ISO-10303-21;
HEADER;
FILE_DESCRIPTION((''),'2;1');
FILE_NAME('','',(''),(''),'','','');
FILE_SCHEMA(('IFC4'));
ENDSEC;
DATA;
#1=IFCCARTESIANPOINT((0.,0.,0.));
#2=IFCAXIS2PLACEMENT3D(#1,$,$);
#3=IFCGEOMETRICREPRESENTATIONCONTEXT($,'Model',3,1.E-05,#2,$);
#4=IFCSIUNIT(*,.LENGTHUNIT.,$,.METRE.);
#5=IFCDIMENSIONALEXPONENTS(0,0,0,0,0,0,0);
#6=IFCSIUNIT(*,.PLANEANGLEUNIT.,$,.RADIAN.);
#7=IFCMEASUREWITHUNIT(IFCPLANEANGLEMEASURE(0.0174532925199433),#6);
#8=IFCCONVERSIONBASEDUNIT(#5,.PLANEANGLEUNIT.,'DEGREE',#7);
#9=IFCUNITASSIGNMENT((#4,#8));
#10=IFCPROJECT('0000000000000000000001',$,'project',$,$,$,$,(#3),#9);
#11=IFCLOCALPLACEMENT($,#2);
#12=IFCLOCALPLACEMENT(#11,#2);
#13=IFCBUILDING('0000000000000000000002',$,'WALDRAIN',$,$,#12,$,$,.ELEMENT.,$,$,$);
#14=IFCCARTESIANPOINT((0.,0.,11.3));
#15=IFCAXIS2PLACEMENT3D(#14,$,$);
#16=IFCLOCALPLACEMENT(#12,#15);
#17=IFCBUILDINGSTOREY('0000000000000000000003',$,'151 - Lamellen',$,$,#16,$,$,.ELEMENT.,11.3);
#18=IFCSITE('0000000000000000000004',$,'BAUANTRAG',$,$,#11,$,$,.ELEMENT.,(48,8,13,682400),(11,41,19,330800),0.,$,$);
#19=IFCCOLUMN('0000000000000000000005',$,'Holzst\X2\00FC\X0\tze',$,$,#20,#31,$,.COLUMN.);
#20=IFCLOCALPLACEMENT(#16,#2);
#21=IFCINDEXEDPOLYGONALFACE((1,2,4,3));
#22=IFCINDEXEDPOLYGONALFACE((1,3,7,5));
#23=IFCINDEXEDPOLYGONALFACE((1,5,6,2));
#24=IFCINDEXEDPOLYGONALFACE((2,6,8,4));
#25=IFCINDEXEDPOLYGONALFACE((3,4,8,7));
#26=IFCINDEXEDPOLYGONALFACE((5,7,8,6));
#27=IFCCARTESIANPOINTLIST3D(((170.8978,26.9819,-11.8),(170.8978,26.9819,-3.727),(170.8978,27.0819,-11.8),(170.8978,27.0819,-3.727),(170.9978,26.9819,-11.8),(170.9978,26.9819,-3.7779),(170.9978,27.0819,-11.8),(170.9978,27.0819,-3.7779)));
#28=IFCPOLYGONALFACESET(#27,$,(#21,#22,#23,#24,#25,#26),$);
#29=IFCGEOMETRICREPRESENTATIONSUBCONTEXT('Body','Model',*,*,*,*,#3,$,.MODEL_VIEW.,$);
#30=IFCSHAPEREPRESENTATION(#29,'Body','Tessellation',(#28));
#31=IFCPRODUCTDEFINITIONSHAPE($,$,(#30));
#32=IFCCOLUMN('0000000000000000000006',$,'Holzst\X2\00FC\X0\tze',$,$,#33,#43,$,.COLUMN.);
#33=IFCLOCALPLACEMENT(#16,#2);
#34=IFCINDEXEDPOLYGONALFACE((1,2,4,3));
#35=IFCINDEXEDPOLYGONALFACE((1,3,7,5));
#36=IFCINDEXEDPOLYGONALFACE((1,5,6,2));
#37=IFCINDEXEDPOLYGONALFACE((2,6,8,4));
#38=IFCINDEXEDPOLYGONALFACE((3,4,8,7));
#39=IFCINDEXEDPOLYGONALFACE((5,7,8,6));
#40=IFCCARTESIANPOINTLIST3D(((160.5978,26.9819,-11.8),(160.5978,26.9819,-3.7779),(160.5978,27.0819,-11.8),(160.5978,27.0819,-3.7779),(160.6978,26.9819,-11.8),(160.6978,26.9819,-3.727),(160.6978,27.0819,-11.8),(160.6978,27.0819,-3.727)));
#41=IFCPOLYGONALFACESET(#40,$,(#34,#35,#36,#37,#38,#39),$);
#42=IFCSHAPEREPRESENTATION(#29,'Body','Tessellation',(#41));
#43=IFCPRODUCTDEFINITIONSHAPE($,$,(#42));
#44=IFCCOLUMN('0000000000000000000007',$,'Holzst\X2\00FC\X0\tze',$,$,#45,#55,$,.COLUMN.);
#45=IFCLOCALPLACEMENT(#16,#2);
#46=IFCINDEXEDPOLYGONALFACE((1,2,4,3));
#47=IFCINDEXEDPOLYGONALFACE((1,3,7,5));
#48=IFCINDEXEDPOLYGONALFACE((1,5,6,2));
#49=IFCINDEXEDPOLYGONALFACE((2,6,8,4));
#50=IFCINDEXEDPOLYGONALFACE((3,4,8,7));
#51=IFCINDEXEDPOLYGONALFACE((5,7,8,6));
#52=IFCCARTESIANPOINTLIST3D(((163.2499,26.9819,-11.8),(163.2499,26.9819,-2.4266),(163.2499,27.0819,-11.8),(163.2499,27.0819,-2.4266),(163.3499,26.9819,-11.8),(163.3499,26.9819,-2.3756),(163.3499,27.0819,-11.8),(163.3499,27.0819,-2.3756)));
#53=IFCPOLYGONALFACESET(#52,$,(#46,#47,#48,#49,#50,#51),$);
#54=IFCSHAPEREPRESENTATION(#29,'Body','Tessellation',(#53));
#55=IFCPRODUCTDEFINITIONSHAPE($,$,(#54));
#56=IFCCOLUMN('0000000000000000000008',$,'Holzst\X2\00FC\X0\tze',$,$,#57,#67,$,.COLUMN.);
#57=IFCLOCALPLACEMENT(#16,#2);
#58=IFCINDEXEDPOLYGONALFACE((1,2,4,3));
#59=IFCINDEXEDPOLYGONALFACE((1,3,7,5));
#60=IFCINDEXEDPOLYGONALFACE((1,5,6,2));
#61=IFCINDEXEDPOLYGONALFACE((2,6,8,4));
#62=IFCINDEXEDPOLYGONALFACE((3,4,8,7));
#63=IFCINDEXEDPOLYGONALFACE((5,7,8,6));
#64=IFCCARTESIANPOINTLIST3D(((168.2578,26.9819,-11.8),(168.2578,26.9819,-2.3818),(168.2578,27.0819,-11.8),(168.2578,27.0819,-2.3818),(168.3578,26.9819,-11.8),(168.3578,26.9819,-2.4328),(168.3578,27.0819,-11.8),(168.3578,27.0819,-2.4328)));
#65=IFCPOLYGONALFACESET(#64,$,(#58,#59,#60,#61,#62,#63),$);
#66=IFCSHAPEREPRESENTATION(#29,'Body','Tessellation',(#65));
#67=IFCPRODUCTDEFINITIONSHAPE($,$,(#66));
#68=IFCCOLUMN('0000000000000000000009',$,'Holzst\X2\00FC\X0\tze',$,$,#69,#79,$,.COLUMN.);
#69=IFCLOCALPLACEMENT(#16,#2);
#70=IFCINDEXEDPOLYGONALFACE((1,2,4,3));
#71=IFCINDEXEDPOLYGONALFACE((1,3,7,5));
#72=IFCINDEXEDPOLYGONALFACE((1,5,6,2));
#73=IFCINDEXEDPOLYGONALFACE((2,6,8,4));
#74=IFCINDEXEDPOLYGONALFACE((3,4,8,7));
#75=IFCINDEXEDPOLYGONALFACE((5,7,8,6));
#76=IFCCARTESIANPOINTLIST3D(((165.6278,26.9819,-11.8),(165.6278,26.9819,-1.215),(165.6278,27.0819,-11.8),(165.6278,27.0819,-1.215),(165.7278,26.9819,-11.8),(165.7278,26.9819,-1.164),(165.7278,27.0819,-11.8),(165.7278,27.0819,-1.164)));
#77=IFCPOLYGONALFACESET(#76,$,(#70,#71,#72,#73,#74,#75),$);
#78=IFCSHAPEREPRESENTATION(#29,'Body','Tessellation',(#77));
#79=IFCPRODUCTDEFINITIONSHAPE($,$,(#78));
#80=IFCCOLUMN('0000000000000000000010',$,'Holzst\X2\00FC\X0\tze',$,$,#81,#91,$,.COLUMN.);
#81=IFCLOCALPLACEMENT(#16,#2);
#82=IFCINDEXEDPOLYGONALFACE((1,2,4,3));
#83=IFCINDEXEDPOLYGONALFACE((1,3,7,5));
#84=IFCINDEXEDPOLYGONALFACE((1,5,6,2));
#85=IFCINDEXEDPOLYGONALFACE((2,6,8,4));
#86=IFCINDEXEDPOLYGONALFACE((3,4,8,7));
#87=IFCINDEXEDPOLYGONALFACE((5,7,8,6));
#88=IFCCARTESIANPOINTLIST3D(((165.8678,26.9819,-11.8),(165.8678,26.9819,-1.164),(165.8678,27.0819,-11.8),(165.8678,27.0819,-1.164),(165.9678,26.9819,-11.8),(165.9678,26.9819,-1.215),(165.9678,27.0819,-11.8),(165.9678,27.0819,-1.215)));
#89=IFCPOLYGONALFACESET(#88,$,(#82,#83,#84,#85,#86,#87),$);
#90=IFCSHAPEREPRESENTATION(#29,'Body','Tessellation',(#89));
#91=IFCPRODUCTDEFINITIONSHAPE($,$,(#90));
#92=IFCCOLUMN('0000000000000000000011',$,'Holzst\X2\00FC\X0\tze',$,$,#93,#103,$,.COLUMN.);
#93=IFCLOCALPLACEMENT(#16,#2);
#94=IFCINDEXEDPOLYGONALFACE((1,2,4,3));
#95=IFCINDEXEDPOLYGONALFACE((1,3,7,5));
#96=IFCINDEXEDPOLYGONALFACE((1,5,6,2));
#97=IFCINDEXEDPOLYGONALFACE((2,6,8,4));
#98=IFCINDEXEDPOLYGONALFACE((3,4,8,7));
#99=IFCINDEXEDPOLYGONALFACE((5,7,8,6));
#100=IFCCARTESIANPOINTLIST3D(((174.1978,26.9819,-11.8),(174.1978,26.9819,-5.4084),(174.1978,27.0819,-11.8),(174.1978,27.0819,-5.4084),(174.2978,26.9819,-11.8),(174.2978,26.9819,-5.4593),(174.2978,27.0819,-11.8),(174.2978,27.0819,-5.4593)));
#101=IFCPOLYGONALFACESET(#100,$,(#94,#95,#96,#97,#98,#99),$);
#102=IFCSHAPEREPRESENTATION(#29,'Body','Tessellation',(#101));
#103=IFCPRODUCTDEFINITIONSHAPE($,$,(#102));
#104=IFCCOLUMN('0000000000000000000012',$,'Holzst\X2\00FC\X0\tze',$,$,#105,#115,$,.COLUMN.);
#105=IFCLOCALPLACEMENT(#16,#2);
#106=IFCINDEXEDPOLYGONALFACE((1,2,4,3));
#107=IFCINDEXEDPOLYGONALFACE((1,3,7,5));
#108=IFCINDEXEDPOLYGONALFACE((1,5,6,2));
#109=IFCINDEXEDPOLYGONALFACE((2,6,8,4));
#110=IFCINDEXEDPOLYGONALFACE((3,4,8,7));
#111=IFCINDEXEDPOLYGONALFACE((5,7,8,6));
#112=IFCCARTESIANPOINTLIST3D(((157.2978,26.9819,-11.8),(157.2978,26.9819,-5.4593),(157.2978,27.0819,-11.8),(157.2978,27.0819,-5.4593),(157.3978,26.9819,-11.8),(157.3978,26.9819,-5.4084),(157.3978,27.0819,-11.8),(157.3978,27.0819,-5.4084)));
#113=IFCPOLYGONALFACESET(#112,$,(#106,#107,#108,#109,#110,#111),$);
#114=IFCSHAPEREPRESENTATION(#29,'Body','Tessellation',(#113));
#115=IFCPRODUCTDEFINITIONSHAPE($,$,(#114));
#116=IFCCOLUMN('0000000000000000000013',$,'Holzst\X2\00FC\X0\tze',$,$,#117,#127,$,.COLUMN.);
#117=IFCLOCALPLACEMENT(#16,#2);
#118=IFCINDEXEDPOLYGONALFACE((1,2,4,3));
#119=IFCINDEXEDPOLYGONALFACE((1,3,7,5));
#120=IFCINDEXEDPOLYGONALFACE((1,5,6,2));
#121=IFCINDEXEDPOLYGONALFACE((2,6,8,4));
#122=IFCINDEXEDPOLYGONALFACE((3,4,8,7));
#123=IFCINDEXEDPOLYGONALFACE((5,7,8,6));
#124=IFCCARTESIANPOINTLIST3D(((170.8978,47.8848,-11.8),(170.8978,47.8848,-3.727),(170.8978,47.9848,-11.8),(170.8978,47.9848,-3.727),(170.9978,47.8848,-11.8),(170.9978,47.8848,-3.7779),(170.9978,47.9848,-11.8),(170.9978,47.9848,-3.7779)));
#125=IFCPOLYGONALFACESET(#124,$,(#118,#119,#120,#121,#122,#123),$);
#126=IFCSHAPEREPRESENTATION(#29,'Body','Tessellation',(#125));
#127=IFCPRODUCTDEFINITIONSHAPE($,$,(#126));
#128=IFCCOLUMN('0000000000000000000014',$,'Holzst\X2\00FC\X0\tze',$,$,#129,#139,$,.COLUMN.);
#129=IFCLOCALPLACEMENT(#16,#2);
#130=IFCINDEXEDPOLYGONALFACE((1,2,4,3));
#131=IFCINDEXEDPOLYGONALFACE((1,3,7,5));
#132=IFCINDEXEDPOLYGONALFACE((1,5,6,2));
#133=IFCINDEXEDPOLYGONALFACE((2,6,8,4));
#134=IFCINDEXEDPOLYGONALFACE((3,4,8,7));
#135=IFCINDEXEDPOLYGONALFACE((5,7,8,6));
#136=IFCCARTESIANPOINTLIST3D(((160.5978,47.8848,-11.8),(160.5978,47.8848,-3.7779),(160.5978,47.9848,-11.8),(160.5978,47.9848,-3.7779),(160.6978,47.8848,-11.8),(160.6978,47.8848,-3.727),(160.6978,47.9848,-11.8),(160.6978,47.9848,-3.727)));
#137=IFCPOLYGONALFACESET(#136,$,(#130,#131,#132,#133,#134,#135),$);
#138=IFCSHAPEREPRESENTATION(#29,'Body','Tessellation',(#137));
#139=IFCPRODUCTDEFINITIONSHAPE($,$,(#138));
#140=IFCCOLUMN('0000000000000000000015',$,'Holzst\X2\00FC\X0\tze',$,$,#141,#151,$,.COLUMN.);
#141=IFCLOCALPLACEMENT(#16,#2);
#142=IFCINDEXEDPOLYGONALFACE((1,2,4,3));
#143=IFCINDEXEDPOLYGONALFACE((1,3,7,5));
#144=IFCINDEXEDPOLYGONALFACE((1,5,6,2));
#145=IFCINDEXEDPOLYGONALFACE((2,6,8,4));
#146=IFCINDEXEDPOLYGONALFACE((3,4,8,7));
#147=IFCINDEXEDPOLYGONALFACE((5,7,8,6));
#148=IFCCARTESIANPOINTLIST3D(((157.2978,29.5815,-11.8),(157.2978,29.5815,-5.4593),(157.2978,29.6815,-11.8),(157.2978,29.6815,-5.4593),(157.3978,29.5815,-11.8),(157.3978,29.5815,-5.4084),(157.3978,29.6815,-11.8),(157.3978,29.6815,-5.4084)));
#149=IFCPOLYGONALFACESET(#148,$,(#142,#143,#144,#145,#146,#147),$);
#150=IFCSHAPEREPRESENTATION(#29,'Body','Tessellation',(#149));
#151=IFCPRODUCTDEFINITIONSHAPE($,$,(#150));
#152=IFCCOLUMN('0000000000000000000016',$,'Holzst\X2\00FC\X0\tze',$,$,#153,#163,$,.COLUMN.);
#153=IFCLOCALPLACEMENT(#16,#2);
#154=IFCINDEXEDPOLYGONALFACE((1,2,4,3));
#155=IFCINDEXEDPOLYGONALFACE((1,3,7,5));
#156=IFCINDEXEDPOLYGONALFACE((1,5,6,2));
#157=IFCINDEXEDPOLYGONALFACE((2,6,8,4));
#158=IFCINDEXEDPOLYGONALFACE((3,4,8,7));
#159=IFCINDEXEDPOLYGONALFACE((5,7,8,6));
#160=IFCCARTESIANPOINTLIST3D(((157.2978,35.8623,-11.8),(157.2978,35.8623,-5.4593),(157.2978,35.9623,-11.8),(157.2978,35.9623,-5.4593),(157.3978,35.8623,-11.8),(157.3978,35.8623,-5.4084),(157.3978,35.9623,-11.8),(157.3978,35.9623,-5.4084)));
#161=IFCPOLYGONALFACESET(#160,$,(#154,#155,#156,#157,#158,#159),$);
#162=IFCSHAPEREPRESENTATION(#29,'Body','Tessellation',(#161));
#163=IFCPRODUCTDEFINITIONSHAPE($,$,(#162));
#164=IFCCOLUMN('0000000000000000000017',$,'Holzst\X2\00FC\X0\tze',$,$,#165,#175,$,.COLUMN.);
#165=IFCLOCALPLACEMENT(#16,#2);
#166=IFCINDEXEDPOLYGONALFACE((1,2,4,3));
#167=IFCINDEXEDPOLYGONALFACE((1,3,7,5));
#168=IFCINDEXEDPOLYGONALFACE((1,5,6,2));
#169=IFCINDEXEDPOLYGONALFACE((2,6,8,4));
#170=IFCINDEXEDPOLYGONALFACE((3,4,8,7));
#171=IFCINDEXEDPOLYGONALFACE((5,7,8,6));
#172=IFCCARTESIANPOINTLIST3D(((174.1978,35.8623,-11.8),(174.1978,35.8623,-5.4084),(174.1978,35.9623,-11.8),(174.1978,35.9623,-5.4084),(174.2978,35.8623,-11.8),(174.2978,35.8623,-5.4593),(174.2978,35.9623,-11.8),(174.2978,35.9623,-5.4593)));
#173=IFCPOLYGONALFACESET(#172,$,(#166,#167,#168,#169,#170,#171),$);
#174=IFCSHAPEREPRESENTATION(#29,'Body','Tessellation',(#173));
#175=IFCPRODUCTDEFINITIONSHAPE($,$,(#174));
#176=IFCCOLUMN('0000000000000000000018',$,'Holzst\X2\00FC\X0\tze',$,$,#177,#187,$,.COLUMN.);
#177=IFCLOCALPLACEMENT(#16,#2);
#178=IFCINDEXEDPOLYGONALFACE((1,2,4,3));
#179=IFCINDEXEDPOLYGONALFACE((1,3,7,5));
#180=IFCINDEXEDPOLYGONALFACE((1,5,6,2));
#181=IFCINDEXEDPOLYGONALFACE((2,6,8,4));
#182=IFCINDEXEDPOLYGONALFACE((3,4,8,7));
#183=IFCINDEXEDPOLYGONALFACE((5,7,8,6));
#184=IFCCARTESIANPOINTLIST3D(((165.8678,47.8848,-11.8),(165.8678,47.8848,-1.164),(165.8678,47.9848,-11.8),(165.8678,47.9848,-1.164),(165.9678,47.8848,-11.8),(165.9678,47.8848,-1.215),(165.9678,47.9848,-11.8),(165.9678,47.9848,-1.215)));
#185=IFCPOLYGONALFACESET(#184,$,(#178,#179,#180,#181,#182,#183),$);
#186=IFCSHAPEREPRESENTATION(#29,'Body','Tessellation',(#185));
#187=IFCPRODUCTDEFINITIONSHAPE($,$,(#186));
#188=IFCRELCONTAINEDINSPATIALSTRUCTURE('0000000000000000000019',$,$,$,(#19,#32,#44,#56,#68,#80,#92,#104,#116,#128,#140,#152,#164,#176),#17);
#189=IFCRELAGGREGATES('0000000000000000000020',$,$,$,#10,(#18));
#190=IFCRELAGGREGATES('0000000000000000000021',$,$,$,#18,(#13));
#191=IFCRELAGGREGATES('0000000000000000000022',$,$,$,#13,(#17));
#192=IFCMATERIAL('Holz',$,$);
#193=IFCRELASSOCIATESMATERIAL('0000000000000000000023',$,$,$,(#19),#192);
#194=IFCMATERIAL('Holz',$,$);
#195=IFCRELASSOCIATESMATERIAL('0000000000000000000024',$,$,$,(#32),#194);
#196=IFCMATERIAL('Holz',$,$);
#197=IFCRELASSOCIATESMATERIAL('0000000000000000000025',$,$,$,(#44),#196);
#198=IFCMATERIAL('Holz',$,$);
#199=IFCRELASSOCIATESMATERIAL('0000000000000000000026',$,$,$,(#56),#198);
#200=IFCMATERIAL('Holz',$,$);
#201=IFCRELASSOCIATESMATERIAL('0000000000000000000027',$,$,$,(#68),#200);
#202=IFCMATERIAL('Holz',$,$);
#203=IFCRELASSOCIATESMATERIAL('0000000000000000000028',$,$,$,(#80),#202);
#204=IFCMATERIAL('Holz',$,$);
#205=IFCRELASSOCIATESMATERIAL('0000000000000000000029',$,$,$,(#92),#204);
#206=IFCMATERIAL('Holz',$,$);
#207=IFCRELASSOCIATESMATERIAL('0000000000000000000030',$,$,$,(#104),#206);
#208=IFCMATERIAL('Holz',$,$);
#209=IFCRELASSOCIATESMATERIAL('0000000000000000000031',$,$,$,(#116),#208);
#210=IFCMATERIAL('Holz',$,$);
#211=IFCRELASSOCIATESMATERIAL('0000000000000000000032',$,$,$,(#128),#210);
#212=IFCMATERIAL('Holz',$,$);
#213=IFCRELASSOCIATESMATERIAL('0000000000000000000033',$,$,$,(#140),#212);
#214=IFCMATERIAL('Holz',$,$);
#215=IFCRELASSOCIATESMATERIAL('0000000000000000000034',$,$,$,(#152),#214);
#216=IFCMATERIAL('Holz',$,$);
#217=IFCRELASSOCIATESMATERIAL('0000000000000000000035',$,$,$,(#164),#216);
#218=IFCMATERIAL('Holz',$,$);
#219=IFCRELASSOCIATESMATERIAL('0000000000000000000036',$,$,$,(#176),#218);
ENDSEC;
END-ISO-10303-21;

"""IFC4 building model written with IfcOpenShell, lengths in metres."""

from ifc_helpers import new_model, entity, si_unit, converted_unit, frame, frame_2d, origin, origin_with_axes, place, context, subcontext, project, spatial, rectangle, extrude, clip, halfspace, material, element, save


model = new_model("IFC4")

# Units and contexts
model_context = context("Model", 3, precision=1e-05, world=origin())
body_context = subcontext(model_context, "Body", "Model", "MODEL_VIEW")
ifc_project = project(units=[si_unit("LENGTHUNIT", "METRE"), converted_unit("PLANEANGLEUNIT", "DEGREE", entity("IfcPlaneAngleMeasure", 0.0174532925199433), si_unit("PLANEANGLEUNIT", "RADIAN"), dimensions=[0, 0, 0, 0, 0, 0, 0])], contexts=[model_context])

# Site, building, storey
site_placement = place(None, origin())
site = spatial("IfcSite", under=ifc_project, at=site_placement, Name="BAUANTRAG", CompositionType="ELEMENT", RefLatitude=(48, 8, 13, 682400), RefLongitude=(11, 41, 19, 330800), RefElevation=0.0)
building_placement = place(site_placement, origin())
building = spatial("IfcBuilding", under=site, at=building_placement, Name="WALDRAIN", CompositionType="ELEMENT")
storey_placement = place(building_placement, frame((0.0, 0.0, 11.3)))
storey = spatial("IfcBuildingStorey", under=building, at=storey_placement, Name="151 - Lamellen", CompositionType="ELEMENT", Elevation=11.3)

# Columns
ifc_material_1 = material(Name="Holz")
column_1_placement = place(storey_placement, frame((170.9978, 26.9819, -11.8)))
element("IfcColumn", 1, at=column_1_placement, inside=storey, material=ifc_material_1, Name="Holzstütze", PredefinedType="COLUMN", context=body_context, shape_type="Clipping", body=[
    clip(extrude(rectangle(XDim=0.1, YDim=0.1, at=frame_2d((-0.05, 0.05), x_axis=(0.0, 1.0))), origin_with_axes(), (0.0, 0.0, 1.0), 8.073), halfspace(frame((-0.05, 0.05, 8.0476), z_axis=(-0.45399, 0.0, -0.891007), x_axis=(0.0, -1.0, 0.0)), True)),
])
ifc_material_2 = material(Name="Holz")
column_2_placement = place(storey_placement, frame((160.6978, 26.9819, -11.8)))
element("IfcColumn", 2, at=column_2_placement, inside=storey, material=ifc_material_2, Name="Holzstütze", PredefinedType="COLUMN", context=body_context, shape_type="Clipping", body=[
    clip(extrude(rectangle(XDim=0.1, YDim=0.1, at=frame_2d((-0.05, 0.05), x_axis=(0.0, 1.0))), origin_with_axes(), (0.0, 0.0, 1.0), 8.073), halfspace(frame((-0.05, 0.05, 8.0476), z_axis=(0.45399, 0.0, -0.891007), x_axis=(0.0, -1.0, 0.0)), True)),
])
ifc_material_3 = material(Name="Holz")
column_3_placement = place(storey_placement, frame((163.3499, 26.9819, -11.8)))
element("IfcColumn", 3, at=column_3_placement, inside=storey, material=ifc_material_3, Name="Holzstütze", PredefinedType="COLUMN", context=body_context, shape_type="Clipping", body=[
    clip(extrude(rectangle(XDim=0.1, YDim=0.1, at=frame_2d((-0.05, 0.05), x_axis=(0.0, 1.0))), origin_with_axes(), (0.0, 0.0, 1.0), 9.4244), halfspace(frame((-0.05, 0.05, 9.3989), z_axis=(0.45399, 0.0, -0.891007), x_axis=(0.0, -1.0, 0.0)), True)),
])
ifc_material_4 = material(Name="Holz")
column_4_placement = place(storey_placement, frame((168.3578, 26.9819, -11.8)))
element("IfcColumn", 4, at=column_4_placement, inside=storey, material=ifc_material_4, Name="Holzstütze", PredefinedType="COLUMN", context=body_context, shape_type="Clipping", body=[
    clip(extrude(rectangle(XDim=0.1, YDim=0.1, at=frame_2d((-0.05, 0.05), x_axis=(0.0, 1.0))), origin_with_axes(), (0.0, 0.0, 1.0), 9.4182), halfspace(frame((-0.05, 0.05, 9.3927), z_axis=(-0.45399, 0.0, -0.891007), x_axis=(0.0, -1.0, 0.0)), True)),
])
ifc_material_5 = material(Name="Holz")
column_5_placement = place(storey_placement, frame((165.7278, 26.9819, -11.8)))
element("IfcColumn", 5, at=column_5_placement, inside=storey, material=ifc_material_5, Name="Holzstütze", PredefinedType="COLUMN", context=body_context, shape_type="Clipping", body=[
    clip(extrude(rectangle(XDim=0.1, YDim=0.1, at=frame_2d((-0.05, 0.05), x_axis=(0.0, 1.0))), origin_with_axes(), (0.0, 0.0, 1.0), 10.636), halfspace(frame((-0.05, 0.05, 10.6105), z_axis=(0.45399, 0.0, -0.891007), x_axis=(0.0, -1.0, 0.0)), True)),
])
ifc_material_6 = material(Name="Holz")
column_6_placement = place(storey_placement, frame((165.9678, 26.9819, -11.8)))
element("IfcColumn", 6, at=column_6_placement, inside=storey, material=ifc_material_6, Name="Holzstütze", PredefinedType="COLUMN", context=body_context, shape_type="Clipping", body=[
    clip(extrude(rectangle(XDim=0.1, YDim=0.1, at=frame_2d((-0.05, 0.05), x_axis=(0.0, 1.0))), origin_with_axes(), (0.0, 0.0, 1.0), 10.636), halfspace(frame((-0.05, 0.05, 10.6105), z_axis=(-0.45399, 0.0, -0.891007), x_axis=(0.0, -1.0, 0.0)), True)),
])
ifc_material_7 = material(Name="Holz")
column_7_placement = place(storey_placement, frame((174.2978, 26.9819, -11.8)))
element("IfcColumn", 7, at=column_7_placement, inside=storey, material=ifc_material_7, Name="Holzstütze", PredefinedType="COLUMN", context=body_context, shape_type="Clipping", body=[
    clip(extrude(rectangle(XDim=0.1, YDim=0.1, at=frame_2d((-0.05, 0.05), x_axis=(0.0, 1.0))), origin_with_axes(), (0.0, 0.0, 1.0), 6.3916), halfspace(frame((-0.05, 0.05, 6.3661), z_axis=(-0.45399, 0.0, -0.891007), x_axis=(0.0, -1.0, 0.0)), True)),
])
ifc_material_8 = material(Name="Holz")
column_8_placement = place(storey_placement, frame((157.3978, 26.9819, -11.8)))
element("IfcColumn", 8, at=column_8_placement, inside=storey, material=ifc_material_8, Name="Holzstütze", PredefinedType="COLUMN", context=body_context, shape_type="Clipping", body=[
    clip(extrude(rectangle(XDim=0.1, YDim=0.1, at=frame_2d((-0.05, 0.05), x_axis=(0.0, 1.0))), origin_with_axes(), (0.0, 0.0, 1.0), 6.3916), halfspace(frame((-0.05, 0.05, 6.3661), z_axis=(0.45399, 0.0, -0.891007), x_axis=(-0.891007, 0.0, -0.45399)), True)),
])
ifc_material_9 = material(Name="Holz")
column_9_placement = place(storey_placement, frame((170.9978, 47.8848, -11.8)))
element("IfcColumn", 9, at=column_9_placement, inside=storey, material=ifc_material_9, Name="Holzstütze", PredefinedType="COLUMN", context=body_context, shape_type="Clipping", body=[
    clip(extrude(rectangle(XDim=0.1, YDim=0.1, at=frame_2d((-0.05, 0.05), x_axis=(0.0, 1.0))), origin_with_axes(), (0.0, 0.0, 1.0), 8.073), halfspace(frame((-0.05, 0.05, 8.0476), z_axis=(-0.45399, 0.0, -0.891007), x_axis=(0.0, 1.0, 0.0)), True)),
])
ifc_material_10 = material(Name="Holz")
column_10_placement = place(storey_placement, frame((160.6978, 47.8848, -11.8)))
element("IfcColumn", 10, at=column_10_placement, inside=storey, material=ifc_material_10, Name="Holzstütze", PredefinedType="COLUMN", context=body_context, shape_type="Clipping", body=[
    clip(extrude(rectangle(XDim=0.1, YDim=0.1, at=frame_2d((-0.05, 0.05), x_axis=(0.0, 1.0))), origin_with_axes(), (0.0, 0.0, 1.0), 8.073), halfspace(frame((-0.05, 0.05, 8.0476), z_axis=(0.45399, 0.0, -0.891007), x_axis=(0.0, 1.0, 0.0)), True)),
])
ifc_material_11 = material(Name="Holz")
column_11_placement = place(storey_placement, frame((157.3978, 29.5815, -11.8)))
element("IfcColumn", 11, at=column_11_placement, inside=storey, material=ifc_material_11, Name="Holzstütze", PredefinedType="COLUMN", context=body_context, shape_type="Clipping", body=[
    clip(extrude(rectangle(XDim=0.1, YDim=0.1, at=frame_2d((-0.05, 0.05), x_axis=(0.0, 1.0))), origin_with_axes(), (0.0, 0.0, 1.0), 6.3916), halfspace(frame((-0.05, 0.05, 6.3661), z_axis=(0.45399, 0.0, -0.891007), x_axis=(-0.891007, 0.0, -0.45399)), True)),
])
ifc_material_12 = material(Name="Holz")
column_12_placement = place(storey_placement, frame((157.3978, 35.8623, -11.8)))
element("IfcColumn", 12, at=column_12_placement, inside=storey, material=ifc_material_12, Name="Holzstütze", PredefinedType="COLUMN", context=body_context, shape_type="Clipping", body=[
    clip(extrude(rectangle(XDim=0.1, YDim=0.1, at=frame_2d((-0.05, 0.05), x_axis=(0.0, 1.0))), origin_with_axes(), (0.0, 0.0, 1.0), 6.3916), halfspace(frame((-0.05, 0.05, 6.3661), z_axis=(0.45399, 0.0, -0.891007), x_axis=(-0.891007, 0.0, -0.45399)), True)),
])
ifc_material_13 = material(Name="Holz")
column_13_placement = place(storey_placement, frame((174.2978, 35.8623, -11.8)))
element("IfcColumn", 13, at=column_13_placement, inside=storey, material=ifc_material_13, Name="Holzstütze", PredefinedType="COLUMN", context=body_context, shape_type="Clipping", body=[
    clip(extrude(rectangle(XDim=0.1, YDim=0.1, at=frame_2d((-0.05, 0.05), x_axis=(0.0, 1.0))), origin_with_axes(), (0.0, 0.0, 1.0), 6.3916), halfspace(frame((-0.05, 0.05, 6.3661), z_axis=(-0.45399, 0.0, -0.891007), x_axis=(0.891007, 0.0, -0.45399)), True)),
])
ifc_material_14 = material(Name="Holz")
column_14_placement = place(storey_placement, frame((165.9678, 47.8848, -11.8)))
element("IfcColumn", 14, at=column_14_placement, inside=storey, material=ifc_material_14, Name="Holzstütze", PredefinedType="COLUMN", context=body_context, shape_type="Clipping", body=[
    clip(extrude(rectangle(XDim=0.1, YDim=0.1, at=frame_2d((-0.05, 0.05), x_axis=(0.0, 1.0))), origin_with_axes(), (0.0, 0.0, 1.0), 10.636), halfspace(frame((-0.05, 0.05, 10.6105), z_axis=(-0.45399, 0.0, -0.891007), x_axis=(0.0, 1.0, 0.0)), True)),
])

save(model, "model.ifc")
